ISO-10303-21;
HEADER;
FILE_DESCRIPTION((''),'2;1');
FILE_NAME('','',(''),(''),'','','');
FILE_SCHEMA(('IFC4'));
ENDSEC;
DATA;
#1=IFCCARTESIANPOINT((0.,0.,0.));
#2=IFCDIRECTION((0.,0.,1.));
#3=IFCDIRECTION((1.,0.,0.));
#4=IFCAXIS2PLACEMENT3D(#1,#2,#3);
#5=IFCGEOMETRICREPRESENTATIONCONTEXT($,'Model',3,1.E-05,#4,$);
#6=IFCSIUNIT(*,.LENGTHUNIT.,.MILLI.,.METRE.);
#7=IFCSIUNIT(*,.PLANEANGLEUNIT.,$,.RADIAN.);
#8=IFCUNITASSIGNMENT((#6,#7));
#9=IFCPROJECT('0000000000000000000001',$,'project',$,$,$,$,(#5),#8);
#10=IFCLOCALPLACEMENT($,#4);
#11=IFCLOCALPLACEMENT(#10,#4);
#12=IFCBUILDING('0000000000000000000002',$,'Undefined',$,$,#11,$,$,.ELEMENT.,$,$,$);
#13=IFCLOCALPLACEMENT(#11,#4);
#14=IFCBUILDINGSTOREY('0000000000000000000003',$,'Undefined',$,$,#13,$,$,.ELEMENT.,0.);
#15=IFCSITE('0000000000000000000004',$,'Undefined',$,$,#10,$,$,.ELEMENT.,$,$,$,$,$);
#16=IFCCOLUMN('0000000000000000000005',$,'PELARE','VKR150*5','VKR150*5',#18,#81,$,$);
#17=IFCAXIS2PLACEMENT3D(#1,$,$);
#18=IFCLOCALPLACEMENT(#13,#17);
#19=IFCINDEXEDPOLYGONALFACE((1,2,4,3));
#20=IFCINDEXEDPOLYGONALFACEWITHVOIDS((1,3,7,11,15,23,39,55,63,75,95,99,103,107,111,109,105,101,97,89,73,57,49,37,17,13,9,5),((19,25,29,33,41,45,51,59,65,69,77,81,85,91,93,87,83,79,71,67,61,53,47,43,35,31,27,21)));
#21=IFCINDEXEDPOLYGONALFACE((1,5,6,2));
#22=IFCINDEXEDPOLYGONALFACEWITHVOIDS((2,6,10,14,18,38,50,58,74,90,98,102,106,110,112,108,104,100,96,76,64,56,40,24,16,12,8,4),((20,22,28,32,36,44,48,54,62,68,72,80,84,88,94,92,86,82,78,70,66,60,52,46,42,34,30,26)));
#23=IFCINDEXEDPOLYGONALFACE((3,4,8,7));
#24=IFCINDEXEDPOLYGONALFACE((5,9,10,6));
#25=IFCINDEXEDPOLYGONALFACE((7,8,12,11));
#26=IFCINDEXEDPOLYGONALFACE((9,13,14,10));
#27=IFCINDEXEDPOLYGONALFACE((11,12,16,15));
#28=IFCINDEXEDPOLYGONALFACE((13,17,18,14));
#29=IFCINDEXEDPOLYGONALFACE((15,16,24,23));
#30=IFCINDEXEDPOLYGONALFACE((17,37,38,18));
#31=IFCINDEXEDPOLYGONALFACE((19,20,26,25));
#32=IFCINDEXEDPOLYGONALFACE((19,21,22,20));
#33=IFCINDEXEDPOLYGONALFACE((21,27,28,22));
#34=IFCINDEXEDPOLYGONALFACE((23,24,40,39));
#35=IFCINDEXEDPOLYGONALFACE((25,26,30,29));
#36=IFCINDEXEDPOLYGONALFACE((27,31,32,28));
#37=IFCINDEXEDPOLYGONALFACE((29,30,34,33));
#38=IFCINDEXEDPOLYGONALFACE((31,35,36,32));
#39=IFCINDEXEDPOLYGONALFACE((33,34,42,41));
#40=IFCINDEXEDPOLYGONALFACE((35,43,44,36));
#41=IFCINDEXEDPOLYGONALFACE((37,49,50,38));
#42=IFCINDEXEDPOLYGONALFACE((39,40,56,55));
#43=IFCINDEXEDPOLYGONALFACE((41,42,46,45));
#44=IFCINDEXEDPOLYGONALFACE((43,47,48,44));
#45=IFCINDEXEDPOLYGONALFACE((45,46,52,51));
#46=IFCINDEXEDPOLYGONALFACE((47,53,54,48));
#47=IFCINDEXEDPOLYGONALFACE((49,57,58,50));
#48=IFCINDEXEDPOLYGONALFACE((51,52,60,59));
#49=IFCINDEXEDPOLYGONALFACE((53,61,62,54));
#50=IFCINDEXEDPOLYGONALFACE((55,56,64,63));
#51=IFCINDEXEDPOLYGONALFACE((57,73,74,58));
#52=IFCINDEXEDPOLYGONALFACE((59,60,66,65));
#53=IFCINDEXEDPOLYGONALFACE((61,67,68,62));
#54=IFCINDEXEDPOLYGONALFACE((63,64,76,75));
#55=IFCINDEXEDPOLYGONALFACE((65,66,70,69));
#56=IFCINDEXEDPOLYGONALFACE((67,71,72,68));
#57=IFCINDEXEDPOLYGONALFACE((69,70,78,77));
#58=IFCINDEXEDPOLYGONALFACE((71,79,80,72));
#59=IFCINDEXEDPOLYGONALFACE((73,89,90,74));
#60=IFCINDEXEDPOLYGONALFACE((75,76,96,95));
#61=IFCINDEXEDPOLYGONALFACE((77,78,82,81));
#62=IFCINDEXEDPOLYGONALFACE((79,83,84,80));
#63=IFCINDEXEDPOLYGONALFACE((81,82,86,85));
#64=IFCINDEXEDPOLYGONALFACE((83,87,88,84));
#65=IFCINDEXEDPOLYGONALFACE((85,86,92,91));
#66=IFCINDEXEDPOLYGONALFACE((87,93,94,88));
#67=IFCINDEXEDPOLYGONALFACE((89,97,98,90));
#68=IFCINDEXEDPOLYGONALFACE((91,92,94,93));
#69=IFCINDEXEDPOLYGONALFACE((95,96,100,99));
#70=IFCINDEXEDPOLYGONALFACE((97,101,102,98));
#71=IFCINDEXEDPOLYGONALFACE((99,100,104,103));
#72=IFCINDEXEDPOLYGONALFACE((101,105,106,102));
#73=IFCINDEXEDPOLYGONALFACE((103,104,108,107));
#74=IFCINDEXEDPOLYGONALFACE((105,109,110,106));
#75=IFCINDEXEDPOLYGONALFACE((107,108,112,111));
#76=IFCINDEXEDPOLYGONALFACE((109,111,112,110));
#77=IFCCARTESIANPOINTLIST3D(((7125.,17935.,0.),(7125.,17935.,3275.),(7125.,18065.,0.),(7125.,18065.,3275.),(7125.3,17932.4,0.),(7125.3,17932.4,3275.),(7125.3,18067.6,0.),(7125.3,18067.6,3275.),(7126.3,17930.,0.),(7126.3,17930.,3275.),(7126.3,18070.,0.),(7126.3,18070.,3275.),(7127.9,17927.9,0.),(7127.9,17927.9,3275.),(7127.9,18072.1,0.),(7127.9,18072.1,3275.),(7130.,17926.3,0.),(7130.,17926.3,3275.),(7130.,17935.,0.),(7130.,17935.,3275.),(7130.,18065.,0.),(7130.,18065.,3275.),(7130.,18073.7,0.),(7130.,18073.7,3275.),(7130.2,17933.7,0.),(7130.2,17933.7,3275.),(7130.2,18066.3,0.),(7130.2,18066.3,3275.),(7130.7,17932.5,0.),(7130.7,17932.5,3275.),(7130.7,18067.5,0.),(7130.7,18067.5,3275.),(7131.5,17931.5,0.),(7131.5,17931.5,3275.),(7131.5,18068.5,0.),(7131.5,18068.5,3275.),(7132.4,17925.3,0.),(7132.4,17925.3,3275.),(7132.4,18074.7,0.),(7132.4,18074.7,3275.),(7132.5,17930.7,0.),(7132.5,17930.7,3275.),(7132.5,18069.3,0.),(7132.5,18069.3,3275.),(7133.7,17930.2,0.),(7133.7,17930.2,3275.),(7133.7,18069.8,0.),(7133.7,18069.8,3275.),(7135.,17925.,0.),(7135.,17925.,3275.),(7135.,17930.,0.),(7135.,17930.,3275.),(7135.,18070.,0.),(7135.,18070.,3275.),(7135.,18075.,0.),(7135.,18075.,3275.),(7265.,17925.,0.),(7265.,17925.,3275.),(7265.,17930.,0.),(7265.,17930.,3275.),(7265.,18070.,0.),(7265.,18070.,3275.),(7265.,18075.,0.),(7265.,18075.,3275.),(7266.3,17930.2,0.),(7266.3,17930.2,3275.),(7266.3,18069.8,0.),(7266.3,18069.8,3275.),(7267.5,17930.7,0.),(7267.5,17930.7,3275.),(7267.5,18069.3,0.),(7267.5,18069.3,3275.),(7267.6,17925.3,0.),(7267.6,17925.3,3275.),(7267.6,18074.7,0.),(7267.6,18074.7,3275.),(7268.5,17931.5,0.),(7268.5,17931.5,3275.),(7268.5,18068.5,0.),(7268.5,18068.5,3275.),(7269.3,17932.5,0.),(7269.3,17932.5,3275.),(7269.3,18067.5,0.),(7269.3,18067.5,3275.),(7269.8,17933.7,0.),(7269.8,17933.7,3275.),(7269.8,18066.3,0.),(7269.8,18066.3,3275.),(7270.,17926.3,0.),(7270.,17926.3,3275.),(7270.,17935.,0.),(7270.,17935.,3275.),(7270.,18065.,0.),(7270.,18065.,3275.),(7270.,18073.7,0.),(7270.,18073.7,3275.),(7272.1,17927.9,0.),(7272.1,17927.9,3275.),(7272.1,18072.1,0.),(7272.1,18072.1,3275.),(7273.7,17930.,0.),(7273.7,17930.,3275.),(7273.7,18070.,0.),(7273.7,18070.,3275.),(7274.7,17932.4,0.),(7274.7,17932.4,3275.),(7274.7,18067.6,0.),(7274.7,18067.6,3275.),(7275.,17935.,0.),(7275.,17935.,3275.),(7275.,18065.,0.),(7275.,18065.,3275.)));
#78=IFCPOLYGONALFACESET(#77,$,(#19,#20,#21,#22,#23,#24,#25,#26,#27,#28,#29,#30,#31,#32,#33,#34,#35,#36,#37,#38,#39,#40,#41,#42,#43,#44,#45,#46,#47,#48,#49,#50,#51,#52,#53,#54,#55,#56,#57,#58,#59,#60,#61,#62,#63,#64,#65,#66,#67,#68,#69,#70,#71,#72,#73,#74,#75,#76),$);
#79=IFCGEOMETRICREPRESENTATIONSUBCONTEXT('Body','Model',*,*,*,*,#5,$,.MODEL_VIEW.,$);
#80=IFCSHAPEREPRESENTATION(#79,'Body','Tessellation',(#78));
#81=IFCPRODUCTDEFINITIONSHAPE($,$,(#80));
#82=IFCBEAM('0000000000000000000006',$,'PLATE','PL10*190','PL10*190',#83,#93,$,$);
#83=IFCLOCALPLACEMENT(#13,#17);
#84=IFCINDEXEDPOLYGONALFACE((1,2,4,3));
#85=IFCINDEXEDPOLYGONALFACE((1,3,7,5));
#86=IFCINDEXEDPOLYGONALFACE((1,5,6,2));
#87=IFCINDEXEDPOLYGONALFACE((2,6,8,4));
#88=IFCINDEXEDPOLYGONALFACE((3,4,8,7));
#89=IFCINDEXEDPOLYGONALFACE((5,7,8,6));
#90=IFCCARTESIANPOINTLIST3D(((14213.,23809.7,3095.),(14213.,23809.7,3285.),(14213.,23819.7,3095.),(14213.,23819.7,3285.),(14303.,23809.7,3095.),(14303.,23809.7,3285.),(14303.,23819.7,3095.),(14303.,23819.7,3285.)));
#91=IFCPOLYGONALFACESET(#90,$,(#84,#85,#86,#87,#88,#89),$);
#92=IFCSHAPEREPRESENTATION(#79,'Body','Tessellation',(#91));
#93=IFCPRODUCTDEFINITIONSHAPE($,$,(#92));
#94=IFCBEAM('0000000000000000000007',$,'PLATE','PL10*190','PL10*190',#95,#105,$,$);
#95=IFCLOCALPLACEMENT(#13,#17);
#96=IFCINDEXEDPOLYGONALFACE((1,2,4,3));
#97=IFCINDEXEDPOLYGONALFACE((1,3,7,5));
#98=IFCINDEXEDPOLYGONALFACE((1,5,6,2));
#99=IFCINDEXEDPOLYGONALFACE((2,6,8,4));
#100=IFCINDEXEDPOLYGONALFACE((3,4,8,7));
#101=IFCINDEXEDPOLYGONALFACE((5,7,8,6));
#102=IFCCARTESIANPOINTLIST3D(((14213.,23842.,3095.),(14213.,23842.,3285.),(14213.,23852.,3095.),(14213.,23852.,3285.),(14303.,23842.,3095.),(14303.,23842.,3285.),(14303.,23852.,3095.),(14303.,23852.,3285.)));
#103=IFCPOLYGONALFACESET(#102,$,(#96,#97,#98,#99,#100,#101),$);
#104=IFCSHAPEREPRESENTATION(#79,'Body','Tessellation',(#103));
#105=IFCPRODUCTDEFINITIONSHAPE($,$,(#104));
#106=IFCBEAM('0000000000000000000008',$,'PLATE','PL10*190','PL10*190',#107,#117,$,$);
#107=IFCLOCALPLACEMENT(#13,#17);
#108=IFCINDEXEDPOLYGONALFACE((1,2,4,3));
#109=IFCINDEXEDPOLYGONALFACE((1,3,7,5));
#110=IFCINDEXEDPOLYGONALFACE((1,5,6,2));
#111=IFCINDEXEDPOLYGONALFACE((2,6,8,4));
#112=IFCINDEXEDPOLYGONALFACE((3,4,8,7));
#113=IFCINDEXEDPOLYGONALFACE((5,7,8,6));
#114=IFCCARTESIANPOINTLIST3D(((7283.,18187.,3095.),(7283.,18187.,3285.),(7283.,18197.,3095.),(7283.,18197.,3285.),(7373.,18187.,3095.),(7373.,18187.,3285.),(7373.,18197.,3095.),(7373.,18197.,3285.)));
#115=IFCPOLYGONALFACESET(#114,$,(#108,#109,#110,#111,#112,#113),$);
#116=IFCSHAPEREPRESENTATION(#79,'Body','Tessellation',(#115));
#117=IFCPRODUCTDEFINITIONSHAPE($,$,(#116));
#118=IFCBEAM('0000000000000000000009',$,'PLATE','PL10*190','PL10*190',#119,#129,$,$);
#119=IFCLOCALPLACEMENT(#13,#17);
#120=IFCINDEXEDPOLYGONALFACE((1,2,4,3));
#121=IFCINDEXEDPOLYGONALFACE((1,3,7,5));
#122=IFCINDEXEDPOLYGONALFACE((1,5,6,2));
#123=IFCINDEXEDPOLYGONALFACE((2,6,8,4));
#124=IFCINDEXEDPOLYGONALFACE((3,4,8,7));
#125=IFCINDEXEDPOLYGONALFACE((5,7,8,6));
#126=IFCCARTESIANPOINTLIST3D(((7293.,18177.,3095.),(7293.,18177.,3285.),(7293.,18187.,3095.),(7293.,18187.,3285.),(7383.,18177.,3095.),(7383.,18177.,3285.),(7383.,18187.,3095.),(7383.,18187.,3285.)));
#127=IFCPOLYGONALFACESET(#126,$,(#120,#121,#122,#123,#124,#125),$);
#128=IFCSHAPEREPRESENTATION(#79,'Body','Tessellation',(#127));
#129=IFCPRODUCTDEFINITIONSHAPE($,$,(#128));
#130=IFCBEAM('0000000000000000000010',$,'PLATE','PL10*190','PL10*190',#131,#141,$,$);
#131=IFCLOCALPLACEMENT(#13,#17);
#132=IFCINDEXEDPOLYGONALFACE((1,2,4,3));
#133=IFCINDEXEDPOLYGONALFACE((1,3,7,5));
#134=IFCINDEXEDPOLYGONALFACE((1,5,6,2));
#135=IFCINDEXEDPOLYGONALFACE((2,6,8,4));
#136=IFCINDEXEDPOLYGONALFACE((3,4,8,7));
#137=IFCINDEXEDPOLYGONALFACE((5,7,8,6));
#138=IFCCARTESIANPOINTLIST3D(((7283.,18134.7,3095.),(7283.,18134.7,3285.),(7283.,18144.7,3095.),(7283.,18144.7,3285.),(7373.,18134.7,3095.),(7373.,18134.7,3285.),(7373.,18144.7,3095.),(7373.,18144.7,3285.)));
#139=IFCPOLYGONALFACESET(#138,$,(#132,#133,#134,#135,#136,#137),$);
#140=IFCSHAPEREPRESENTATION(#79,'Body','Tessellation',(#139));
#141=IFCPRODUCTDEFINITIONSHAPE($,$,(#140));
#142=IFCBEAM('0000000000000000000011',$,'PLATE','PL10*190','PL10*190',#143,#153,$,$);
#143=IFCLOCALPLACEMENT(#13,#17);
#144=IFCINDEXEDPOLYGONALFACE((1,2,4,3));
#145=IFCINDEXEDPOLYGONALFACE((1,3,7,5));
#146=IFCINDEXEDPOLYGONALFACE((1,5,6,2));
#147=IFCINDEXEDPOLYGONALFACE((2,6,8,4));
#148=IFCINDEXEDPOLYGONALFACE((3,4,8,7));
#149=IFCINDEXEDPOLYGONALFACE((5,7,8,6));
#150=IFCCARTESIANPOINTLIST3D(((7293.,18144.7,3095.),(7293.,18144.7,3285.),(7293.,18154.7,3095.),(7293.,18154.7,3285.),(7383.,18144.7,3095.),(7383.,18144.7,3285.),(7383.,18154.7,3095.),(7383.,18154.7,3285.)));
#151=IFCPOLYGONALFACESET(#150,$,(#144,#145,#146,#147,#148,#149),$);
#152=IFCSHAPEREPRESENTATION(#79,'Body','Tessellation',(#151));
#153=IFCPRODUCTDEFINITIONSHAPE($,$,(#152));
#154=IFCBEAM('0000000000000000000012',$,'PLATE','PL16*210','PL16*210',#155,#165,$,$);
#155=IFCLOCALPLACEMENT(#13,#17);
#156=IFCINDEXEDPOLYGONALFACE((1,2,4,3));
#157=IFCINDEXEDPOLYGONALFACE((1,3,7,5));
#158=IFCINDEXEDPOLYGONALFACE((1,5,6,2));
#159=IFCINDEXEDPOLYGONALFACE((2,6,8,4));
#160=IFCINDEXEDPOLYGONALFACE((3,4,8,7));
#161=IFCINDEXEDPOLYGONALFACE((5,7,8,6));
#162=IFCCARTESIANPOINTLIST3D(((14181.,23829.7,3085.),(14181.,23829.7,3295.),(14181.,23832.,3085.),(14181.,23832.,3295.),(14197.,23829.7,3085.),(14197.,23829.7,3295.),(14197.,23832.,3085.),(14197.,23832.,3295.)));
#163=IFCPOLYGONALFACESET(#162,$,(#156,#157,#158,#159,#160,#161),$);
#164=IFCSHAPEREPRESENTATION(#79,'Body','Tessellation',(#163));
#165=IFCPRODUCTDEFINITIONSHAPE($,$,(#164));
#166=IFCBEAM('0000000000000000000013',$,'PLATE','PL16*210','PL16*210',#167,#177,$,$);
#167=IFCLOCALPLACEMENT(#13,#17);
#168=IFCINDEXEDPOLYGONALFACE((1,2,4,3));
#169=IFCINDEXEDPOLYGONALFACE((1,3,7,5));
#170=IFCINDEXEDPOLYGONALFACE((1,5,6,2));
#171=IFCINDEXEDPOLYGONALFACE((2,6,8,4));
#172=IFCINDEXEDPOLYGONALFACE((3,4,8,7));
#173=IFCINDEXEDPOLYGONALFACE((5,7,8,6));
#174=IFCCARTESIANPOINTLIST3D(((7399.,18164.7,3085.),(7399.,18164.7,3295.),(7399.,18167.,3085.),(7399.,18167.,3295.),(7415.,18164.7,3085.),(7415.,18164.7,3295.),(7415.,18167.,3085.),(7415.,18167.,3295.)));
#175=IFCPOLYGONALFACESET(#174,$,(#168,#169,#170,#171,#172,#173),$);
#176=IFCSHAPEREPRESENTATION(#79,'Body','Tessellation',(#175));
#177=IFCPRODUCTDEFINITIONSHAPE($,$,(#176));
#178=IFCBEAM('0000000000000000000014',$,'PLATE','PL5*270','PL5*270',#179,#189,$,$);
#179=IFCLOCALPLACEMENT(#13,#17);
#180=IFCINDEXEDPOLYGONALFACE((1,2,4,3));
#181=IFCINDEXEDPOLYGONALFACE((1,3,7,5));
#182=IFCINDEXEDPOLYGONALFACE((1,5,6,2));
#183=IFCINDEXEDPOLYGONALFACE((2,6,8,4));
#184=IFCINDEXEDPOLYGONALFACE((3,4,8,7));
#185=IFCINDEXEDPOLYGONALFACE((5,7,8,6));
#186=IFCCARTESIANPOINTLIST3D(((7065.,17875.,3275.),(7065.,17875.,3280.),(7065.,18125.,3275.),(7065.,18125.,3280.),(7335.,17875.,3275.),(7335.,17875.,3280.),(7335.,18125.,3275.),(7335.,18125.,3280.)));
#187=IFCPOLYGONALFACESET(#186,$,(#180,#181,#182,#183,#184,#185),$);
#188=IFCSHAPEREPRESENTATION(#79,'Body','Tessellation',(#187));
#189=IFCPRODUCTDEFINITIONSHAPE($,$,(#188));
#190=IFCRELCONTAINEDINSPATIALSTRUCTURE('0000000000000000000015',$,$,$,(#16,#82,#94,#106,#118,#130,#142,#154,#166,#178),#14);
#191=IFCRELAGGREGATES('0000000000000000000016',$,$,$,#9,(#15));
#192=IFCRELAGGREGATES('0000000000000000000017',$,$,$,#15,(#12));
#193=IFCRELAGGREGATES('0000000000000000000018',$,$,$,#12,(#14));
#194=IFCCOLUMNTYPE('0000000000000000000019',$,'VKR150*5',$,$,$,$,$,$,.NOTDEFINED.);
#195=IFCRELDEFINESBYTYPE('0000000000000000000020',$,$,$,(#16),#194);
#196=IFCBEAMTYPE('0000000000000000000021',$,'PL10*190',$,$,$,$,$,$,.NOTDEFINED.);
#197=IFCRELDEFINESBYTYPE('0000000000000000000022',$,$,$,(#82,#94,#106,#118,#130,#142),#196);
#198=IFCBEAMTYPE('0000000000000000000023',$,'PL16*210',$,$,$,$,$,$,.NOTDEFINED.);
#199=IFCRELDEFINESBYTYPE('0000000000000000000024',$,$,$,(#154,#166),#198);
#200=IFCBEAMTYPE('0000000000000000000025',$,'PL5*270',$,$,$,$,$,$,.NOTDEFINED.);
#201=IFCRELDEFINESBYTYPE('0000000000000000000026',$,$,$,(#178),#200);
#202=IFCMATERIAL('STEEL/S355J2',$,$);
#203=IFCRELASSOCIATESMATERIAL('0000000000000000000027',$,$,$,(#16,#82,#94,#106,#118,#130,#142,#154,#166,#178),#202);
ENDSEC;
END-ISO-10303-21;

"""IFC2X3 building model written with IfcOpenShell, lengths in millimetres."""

from ifc_helpers import new_model, si_unit, frame, origin_with_axes, origin_2d_with_axis, place, context, subcontext, project, spatial, rectangle, hollow_rectangle, extrude, clip, halfspace, material, type_object, element, save


model = new_model("IFC2X3")

# Units and contexts
model_context = context("Model", 3, precision=1e-05, world=origin_with_axes())
body_context = subcontext(model_context, "Body", "Model", "MODEL_VIEW")
ifc_project = project(units=[si_unit("LENGTHUNIT", "METRE", prefix="MILLI"), si_unit("PLANEANGLEUNIT", "RADIAN")], contexts=[model_context])

# Site, building, storey
site_placement = place(None, origin_with_axes())
site = spatial("IfcSite", under=ifc_project, at=site_placement, Name="Undefined", CompositionType="ELEMENT")
building_placement = place(site_placement, origin_with_axes())
building = spatial("IfcBuilding", under=site, at=building_placement, Name="Undefined", CompositionType="ELEMENT")
storey_placement = place(building_placement, origin_with_axes())
storey = spatial("IfcBuildingStorey", under=building, at=storey_placement, Name="Undefined", CompositionType="ELEMENT", Elevation=0.0)

# Column
ifc_material_1 = material(Name="STEEL/S355J2")
column_type = type_object("IfcColumnType", Name="VKR150*5", PredefinedType="NOTDEFINED")
column_placement = place(storey_placement, frame((7200.0, 18000.0, 0.0), z_axis=(0.0, 0.0, 1.0), x_axis=(0.0, 1.0, 0.0)))
element("IfcColumn", 1, at=column_placement, inside=storey, type_object=column_type, material=ifc_material_1, Name="PELARE", Description="VKR150*5", ObjectType="VKR150*5", context=body_context, shape_type="Clipping", body=[
    clip(extrude(hollow_rectangle(XDim=150.0, YDim=150.0, WallThickness=5.0, InnerFilletRadius=5.0, OuterFilletRadius=10.0, at=origin_2d_with_axis()), frame((0.0, 0.0, 3275.0), z_axis=(0.0, 0.0, -1.0), x_axis=(0.0, 1.0, 0.0)), (0.0, 0.0, 1.0), 3275.0), halfspace(frame((125.0, 0.0, 3275.0), z_axis=(0.0, 0.0, 1.0), x_axis=(0.0, -1.0, 0.0)), False)),
])

# Beams
beam_type_1 = type_object("IfcBeamType", Name="PL10*190", PredefinedType="NOTDEFINED")
for number, where, z_axis, x_axis, name in (
    (2, (14303.0, 23814.7, 3190.0), (0.0, 0.0, 1.0), (-1.0, 0.0, 0.0), "PLATE"),
    (3, (14303.0, 23847.0, 3190.0), (0.0, 0.0, 1.0), (-1.0, 0.0, 0.0), "PLATE"),
    (4, (7283.0, 18192.0, 3190.0), (0.0, 0.0, 1.0), (1.0, 0.0, 0.0), "PLATE"),
    (5, (7293.0, 18182.0, 3190.0), (0.0, 0.0, 1.0), (1.0, 0.0, 0.0), "PLATE"),
    (6, (7283.0, 18139.7, 3190.0), (0.0, 0.0, 1.0), (1.0, 0.0, 0.0), "PLATE"),
    (7, (7293.0, 18149.7, 3190.0), (0.0, 0.0, 1.0), (1.0, 0.0, 0.0), "PLATE"),
):
    element("IfcBeam", number, at=place(storey_placement, frame(where, z_axis=z_axis, x_axis=x_axis)), inside=storey, type_object=beam_type_1, material=ifc_material_1, Name=name, Description="PL10*190", ObjectType="PL10*190", context=body_context, shape_type="SweptSolid", body=[
        extrude(rectangle(XDim=10.0, YDim=190.0, at=origin_2d_with_axis()), frame((90.0, 0.0, 0.0), z_axis=(-1.0, 0.0, 0.0), x_axis=(0.0, -1.0, 0.0)), (0.0, 0.0, 1.0), 90.0),
    ])
beam_type_2 = type_object("IfcBeamType", Name="PL16*210", PredefinedType="NOTDEFINED")
for number, where, z_axis, x_axis, name in (
    (8, (14189.0, 23832.0, 3190.0), (0.0, 0.0, 1.0), (0.0, -1.0, 0.0), "PLATE"),
    (9, (7407.0, 18164.7, 3190.0), (0.0, 0.0, 1.0), (0.0, 1.0, 0.0), "PLATE"),
):
    element("IfcBeam", number, at=place(storey_placement, frame(where, z_axis=z_axis, x_axis=x_axis)), inside=storey, type_object=beam_type_2, material=ifc_material_1, Name=name, Description="PL16*210", ObjectType="PL16*210", context=body_context, shape_type="SweptSolid", body=[
        extrude(rectangle(XDim=16.0, YDim=210.0, at=origin_2d_with_axis()), frame((2.3, 0.0, 0.0), z_axis=(-1.0, 0.0, 0.0), x_axis=(0.0, -1.0, 0.0)), (0.0, 0.0, 1.0), 2.3),
    ])
beam_type_3 = type_object("IfcBeamType", Name="PL5*270", PredefinedType="NOTDEFINED")
beam_1_placement = place(storey_placement, frame((7200.0, 18125.0, 3277.5), z_axis=(1.0, 0.0, 0.0), x_axis=(0.0, -1.0, 0.0)))
element("IfcBeam", 10, at=beam_1_placement, inside=storey, type_object=beam_type_3, material=ifc_material_1, Name="PLATE", Description="PL5*270", ObjectType="PL5*270", context=body_context, shape_type="SweptSolid", body=[
    extrude(rectangle(XDim=5.0, YDim=270.0, at=origin_2d_with_axis()), frame((250.0, 0.0, 0.0), z_axis=(-1.0, 0.0, 0.0), x_axis=(0.0, -1.0, 0.0)), (0.0, 0.0, 1.0), 250.0),
])

save(model, "model.ifc")
